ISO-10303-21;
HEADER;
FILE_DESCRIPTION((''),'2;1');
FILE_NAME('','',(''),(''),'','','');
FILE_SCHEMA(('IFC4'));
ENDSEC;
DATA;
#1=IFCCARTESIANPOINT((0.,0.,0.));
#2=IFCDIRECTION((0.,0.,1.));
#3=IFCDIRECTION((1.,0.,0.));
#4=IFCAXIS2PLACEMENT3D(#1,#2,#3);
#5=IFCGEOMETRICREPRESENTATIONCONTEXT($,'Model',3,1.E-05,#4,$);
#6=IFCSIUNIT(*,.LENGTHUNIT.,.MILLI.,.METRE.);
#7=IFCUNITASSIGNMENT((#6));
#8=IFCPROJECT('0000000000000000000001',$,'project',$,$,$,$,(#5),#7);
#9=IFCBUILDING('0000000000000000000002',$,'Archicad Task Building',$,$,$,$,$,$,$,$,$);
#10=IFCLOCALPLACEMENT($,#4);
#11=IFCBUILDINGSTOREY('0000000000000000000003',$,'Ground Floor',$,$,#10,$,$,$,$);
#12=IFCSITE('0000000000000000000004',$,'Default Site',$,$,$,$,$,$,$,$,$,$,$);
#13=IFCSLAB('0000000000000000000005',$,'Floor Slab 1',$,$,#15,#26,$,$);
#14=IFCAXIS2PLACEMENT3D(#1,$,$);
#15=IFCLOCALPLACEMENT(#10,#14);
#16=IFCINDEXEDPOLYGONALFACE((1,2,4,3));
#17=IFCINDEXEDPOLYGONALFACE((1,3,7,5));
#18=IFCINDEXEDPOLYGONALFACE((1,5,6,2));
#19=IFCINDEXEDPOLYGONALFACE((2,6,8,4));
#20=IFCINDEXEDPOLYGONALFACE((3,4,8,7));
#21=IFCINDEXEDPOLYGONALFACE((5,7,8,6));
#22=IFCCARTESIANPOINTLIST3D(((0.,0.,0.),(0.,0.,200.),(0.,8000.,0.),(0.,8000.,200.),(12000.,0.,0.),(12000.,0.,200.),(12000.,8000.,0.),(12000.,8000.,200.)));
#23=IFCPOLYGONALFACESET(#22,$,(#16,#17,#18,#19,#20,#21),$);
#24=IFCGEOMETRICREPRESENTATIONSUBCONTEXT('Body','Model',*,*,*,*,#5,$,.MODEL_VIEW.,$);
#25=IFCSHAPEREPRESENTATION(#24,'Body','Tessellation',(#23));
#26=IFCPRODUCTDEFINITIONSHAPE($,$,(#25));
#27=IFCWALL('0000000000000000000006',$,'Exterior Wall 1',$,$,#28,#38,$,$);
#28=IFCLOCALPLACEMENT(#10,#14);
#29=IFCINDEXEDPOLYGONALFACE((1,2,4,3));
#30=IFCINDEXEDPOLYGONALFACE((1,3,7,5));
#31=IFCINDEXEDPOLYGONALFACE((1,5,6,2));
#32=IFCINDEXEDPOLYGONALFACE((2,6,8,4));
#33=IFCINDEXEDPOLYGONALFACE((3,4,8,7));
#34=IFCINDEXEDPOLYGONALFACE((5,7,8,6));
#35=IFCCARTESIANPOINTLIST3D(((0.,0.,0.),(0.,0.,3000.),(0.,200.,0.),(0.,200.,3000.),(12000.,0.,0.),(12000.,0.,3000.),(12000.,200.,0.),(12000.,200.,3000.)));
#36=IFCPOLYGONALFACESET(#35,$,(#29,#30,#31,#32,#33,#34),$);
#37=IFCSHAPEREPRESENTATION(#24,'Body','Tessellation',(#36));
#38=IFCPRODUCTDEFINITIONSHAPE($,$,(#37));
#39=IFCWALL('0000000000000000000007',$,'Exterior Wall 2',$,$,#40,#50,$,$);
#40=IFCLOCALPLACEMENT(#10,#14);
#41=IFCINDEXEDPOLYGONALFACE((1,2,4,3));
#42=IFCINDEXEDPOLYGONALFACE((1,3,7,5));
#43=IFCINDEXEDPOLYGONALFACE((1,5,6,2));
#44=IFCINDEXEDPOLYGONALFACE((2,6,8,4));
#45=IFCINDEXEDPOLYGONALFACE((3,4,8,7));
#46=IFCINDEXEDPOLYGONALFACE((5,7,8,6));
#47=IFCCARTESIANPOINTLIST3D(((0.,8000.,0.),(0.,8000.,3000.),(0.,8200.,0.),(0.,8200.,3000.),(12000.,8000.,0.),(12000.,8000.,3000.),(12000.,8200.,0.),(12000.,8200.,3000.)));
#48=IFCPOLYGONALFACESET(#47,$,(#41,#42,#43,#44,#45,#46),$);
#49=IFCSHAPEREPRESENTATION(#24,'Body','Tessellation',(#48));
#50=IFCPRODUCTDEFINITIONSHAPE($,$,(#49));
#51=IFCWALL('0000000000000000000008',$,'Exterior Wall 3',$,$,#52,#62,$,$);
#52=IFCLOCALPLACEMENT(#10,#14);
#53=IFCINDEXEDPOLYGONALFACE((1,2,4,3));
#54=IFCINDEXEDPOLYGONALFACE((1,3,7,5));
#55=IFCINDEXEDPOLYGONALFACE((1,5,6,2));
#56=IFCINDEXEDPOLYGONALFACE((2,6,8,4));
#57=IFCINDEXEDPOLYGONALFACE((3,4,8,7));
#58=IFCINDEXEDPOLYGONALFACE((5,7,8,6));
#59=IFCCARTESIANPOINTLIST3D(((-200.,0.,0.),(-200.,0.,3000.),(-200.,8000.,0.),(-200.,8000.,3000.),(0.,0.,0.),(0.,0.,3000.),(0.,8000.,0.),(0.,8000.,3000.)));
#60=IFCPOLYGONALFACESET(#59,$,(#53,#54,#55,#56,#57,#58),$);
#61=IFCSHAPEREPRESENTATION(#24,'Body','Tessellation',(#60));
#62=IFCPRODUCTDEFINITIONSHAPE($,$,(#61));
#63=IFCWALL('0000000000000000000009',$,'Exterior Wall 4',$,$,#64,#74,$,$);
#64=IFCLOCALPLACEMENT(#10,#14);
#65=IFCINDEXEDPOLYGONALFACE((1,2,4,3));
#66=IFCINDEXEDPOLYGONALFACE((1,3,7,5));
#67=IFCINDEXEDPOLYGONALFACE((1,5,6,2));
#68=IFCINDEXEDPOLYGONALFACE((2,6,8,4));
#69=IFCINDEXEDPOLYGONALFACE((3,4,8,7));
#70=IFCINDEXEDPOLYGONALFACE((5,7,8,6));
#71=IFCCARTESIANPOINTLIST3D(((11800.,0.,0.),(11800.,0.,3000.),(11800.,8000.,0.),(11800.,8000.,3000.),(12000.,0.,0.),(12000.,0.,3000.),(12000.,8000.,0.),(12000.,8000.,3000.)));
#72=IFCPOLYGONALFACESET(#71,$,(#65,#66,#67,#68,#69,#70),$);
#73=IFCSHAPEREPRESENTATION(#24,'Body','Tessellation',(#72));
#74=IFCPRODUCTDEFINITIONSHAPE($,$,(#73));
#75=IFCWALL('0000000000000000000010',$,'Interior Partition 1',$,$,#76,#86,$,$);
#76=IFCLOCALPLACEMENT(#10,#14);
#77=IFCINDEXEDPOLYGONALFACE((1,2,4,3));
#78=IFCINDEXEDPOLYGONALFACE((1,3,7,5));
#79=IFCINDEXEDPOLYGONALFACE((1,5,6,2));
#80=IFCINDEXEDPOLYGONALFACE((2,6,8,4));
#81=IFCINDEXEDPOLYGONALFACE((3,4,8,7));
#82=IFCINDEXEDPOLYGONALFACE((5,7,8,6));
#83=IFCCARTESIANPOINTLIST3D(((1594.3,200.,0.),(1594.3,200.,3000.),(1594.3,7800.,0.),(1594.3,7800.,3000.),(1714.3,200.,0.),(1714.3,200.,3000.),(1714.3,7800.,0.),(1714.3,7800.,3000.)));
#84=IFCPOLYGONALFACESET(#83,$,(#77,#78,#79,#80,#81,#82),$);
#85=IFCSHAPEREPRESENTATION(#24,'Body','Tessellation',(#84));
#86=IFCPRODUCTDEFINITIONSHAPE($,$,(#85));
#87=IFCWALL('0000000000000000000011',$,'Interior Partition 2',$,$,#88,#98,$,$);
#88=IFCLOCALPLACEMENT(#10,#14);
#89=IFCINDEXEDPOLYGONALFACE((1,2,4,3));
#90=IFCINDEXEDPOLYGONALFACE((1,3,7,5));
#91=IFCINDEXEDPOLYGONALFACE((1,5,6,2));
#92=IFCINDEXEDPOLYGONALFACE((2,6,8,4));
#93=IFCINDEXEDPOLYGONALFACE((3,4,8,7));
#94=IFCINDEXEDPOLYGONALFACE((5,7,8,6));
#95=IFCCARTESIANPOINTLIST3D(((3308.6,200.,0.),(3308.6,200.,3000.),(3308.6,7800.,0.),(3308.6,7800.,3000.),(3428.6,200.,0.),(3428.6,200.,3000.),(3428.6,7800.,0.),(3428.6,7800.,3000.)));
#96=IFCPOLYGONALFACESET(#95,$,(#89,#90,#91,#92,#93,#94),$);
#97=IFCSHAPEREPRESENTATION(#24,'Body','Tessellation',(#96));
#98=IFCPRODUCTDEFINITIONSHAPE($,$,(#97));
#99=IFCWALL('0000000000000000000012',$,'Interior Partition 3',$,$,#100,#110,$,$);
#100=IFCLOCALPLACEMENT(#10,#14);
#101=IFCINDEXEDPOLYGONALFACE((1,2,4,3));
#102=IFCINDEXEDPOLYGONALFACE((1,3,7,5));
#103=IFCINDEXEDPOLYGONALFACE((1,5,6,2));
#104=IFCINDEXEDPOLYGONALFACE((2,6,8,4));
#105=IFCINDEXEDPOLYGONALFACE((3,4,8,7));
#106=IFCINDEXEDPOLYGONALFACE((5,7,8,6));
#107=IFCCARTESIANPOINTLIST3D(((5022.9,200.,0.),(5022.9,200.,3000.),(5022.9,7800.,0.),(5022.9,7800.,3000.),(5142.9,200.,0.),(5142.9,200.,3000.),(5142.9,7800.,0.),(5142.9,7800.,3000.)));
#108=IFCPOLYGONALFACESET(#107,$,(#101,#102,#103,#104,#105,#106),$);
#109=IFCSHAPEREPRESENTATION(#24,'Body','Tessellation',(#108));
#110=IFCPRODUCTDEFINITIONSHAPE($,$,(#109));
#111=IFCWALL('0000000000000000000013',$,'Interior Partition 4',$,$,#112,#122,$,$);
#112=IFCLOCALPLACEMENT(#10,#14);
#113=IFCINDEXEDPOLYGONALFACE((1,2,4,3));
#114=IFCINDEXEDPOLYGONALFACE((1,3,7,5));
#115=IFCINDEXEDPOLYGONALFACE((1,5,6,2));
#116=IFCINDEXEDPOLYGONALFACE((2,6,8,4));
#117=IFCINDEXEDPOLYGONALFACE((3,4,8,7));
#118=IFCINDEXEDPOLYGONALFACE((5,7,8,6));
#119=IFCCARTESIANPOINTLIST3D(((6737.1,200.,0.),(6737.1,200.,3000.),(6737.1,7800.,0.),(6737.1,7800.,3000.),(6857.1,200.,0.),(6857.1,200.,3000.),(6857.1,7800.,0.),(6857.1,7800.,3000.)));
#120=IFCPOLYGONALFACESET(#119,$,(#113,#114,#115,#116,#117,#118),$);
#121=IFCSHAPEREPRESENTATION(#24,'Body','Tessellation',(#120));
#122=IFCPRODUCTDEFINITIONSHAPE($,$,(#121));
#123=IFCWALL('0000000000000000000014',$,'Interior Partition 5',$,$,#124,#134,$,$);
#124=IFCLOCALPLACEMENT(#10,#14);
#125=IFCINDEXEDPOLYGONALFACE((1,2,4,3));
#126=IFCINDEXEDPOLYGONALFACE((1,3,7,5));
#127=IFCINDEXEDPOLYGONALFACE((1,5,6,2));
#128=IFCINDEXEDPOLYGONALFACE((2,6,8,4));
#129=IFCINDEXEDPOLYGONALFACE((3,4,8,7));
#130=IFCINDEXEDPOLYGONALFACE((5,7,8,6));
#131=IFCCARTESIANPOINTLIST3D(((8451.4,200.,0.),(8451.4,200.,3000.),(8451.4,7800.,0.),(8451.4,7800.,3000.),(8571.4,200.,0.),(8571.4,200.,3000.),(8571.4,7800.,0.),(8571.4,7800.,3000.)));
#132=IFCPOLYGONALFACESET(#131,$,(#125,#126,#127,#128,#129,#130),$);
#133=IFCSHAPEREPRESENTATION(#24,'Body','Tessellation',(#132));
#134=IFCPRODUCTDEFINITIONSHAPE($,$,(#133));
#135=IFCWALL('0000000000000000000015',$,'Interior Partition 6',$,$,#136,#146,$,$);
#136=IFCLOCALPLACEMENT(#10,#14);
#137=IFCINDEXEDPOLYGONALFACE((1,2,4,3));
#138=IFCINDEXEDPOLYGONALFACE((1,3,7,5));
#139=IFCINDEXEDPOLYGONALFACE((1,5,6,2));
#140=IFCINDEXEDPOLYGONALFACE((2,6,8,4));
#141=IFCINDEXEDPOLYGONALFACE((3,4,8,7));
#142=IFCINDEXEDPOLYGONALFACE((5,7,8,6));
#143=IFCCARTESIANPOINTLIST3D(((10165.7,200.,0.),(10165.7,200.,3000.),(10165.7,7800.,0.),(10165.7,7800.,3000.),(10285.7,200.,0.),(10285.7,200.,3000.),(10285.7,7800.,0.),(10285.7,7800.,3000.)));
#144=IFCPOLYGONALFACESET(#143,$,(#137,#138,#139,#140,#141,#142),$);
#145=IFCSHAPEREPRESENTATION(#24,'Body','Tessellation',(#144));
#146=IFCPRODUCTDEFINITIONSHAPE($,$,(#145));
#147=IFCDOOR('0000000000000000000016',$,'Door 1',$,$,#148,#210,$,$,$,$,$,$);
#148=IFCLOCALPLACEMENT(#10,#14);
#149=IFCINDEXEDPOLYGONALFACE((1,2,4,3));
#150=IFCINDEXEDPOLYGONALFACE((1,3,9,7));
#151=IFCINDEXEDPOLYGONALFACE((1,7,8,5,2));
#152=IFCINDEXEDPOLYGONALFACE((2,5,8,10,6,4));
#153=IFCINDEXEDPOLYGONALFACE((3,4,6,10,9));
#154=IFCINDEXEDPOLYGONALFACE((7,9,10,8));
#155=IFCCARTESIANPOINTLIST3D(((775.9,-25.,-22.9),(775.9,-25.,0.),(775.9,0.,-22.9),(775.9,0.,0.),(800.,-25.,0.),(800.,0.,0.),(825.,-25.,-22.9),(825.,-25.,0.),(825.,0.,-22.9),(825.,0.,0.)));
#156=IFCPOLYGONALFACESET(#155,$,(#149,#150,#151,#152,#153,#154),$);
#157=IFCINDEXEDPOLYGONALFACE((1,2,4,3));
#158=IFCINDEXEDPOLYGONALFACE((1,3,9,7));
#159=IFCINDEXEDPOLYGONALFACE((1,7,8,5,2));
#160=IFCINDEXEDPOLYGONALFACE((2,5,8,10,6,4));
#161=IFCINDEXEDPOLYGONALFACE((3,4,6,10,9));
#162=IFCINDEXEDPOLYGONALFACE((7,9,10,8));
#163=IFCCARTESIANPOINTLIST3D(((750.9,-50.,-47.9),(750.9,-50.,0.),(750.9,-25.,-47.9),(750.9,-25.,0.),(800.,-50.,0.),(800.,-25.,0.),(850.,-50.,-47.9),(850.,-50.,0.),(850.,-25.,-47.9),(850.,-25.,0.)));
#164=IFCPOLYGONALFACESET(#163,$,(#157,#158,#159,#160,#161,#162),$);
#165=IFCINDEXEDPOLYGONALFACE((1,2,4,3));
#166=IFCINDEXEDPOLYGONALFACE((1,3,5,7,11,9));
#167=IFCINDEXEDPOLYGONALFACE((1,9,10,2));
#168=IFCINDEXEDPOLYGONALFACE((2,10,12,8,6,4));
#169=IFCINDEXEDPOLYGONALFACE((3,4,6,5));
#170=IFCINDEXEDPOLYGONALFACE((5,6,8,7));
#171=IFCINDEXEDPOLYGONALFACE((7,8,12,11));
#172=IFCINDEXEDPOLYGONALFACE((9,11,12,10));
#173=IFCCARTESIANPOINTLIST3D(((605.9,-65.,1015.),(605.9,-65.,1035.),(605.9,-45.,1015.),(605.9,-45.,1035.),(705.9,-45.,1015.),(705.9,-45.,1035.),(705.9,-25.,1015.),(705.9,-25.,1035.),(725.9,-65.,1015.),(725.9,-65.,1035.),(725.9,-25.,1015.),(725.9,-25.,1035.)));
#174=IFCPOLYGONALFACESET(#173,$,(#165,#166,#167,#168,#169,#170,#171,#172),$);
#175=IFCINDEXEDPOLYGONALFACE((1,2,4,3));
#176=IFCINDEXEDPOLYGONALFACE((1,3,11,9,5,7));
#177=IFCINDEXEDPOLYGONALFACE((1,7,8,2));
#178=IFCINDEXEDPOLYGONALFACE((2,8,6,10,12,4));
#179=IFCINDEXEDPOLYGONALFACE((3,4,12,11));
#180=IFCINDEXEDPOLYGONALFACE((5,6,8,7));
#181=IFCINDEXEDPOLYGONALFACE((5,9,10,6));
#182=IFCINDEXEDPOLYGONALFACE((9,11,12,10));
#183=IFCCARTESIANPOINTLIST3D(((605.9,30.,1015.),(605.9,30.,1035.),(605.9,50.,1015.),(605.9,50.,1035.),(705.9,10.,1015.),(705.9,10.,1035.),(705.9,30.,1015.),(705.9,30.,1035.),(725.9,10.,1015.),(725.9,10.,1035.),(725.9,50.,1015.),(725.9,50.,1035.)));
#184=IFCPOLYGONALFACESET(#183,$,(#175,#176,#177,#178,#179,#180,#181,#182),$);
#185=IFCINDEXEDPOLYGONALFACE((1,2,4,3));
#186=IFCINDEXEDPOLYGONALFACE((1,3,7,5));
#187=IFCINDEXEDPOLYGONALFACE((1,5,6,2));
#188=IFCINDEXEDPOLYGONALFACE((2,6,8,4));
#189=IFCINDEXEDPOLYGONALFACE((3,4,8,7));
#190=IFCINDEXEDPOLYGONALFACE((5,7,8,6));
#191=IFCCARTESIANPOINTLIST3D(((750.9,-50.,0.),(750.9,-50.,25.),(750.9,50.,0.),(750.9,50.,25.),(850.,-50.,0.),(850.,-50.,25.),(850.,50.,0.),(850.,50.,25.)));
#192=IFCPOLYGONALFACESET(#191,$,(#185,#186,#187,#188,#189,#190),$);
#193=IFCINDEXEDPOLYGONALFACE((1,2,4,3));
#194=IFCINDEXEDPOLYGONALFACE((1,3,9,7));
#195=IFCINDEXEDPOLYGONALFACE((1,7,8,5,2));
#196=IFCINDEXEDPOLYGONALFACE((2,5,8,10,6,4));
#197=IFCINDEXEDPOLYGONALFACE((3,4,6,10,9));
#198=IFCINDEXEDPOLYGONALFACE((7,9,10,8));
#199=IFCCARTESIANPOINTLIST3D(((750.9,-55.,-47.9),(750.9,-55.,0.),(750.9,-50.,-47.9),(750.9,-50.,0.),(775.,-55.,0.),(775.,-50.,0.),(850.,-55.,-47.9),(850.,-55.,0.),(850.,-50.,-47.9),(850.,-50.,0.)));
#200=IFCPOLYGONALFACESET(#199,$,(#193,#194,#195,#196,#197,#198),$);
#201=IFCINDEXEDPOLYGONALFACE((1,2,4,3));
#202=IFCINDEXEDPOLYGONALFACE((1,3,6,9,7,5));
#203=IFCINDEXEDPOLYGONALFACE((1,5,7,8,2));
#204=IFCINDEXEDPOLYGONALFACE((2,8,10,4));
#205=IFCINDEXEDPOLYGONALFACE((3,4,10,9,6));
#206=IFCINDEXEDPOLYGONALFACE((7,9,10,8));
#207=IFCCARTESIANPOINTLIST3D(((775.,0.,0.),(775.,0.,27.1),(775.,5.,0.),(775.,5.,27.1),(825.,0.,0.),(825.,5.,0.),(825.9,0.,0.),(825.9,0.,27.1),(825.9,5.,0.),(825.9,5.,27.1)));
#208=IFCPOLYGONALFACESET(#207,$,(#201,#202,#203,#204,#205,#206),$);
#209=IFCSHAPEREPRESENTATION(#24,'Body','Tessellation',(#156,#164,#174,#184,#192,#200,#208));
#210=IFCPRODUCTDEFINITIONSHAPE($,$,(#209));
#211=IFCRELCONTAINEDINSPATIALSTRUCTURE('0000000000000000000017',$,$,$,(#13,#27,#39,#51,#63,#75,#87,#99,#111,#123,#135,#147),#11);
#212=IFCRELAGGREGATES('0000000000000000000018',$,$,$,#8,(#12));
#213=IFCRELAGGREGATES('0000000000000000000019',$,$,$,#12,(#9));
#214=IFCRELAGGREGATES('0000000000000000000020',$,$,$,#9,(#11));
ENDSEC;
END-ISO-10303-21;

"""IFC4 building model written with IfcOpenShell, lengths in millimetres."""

from ifc_helpers import new_model, si_unit, frame, origin_with_axes, place, context, subcontext, project, spatial, line, indexed_curve, outline, extrude, element, save


model = new_model("IFC4")

# Units and contexts
model_context = context("Model", 3, precision=1e-05, world=origin_with_axes())
body_context = subcontext(model_context, "Body", "Model", "MODEL_VIEW")
ifc_project = project(units=[si_unit("LENGTHUNIT", "METRE", prefix="MILLI")], contexts=[model_context])

# Site, building, storey
site = spatial("IfcSite", under=ifc_project, Name="Default Site")
building = spatial("IfcBuilding", under=site, Name="Archicad Task Building")
storey_placement = place(None, origin_with_axes())
storey = spatial("IfcBuildingStorey", under=building, at=storey_placement, Name="Ground Floor")

# Slab
slab_placement = place(storey_placement, origin_with_axes())
element("IfcSlab", 1, at=slab_placement, inside=storey, Name="Floor Slab 1", context=body_context, shape_type="SweptSolid", body=[
    extrude(outline(indexed_curve([(0.0, 0.0), (12000.0, 0.0), (12000.0, 8000.0), (0.0, 8000.0), (0.0, 0.0)])), None, (0.0, 0.0, 1.0), 200.0),
])

# Walls
for number, where, z_axis, x_axis, name in (
    (2, (0.0, 0.0, 0.0), (0.0, 0.0, 1.0), (1.0, 0.0, 0.0), "Exterior Wall 1"),
    (3, (0.0, 8000.0, 0.0), (0.0, 0.0, 1.0), (1.0, 0.0, 0.0), "Exterior Wall 2"),
):
    element("IfcWall", number, at=place(storey_placement, frame(where, z_axis=z_axis, x_axis=x_axis)), inside=storey, Name=name, context=body_context, shape_type="SweptSolid", body=[
        extrude(outline(indexed_curve([(0.0, 0.0), (0.0, 200.0), (12000.0, 200.0), (12000.0, 0.0), (0.0, 0.0)], self_intersect=False)), origin_with_axes(), (0.0, 0.0, 1.0), 3000.0),
    ])
for number, where, z_axis, x_axis, name in (
    (4, (0.0, 0.0, 0.0), (0.0, 0.0, 1.0), (0.0, 1.0, 0.0), "Exterior Wall 3"),
    (5, (12000.0, 0.0, 0.0), (0.0, 0.0, 1.0), (0.0, 1.0, 0.0), "Exterior Wall 4"),
):
    element("IfcWall", number, at=place(storey_placement, frame(where, z_axis=z_axis, x_axis=x_axis)), inside=storey, Name=name, context=body_context, shape_type="SweptSolid", body=[
        extrude(outline(indexed_curve([(0.0, 0.0), (0.0, 200.0), (8000.0, 200.0), (8000.0, 0.0), (0.0, 0.0)], self_intersect=False)), origin_with_axes(), (0.0, 0.0, 1.0), 3000.0),
    ])
for number, where, z_axis, x_axis, name in (
    (6, (1714.3, 200.0, 0.0), (0.0, 0.0, 1.0), (0.0, 1.0, 0.0), "Interior Partition 1"),
    (7, (3428.6, 200.0, 0.0), (0.0, 0.0, 1.0), (0.0, 1.0, 0.0), "Interior Partition 2"),
    (8, (5142.9, 200.0, 0.0), (0.0, 0.0, 1.0), (0.0, 1.0, 0.0), "Interior Partition 3"),
    (9, (6857.1, 200.0, 0.0), (0.0, 0.0, 1.0), (0.0, 1.0, 0.0), "Interior Partition 4"),
    (10, (8571.4, 200.0, 0.0), (0.0, 0.0, 1.0), (0.0, 1.0, 0.0), "Interior Partition 5"),
    (11, (10285.7, 200.0, 0.0), (0.0, 0.0, 1.0), (0.0, 1.0, 0.0), "Interior Partition 6"),
):
    element("IfcWall", number, at=place(storey_placement, frame(where, z_axis=z_axis, x_axis=x_axis)), inside=storey, Name=name, context=body_context, shape_type="SweptSolid", body=[
        extrude(outline(indexed_curve([(0.0, 0.0), (0.0, 120.0), (7600.0, 120.0), (7600.0, 0.0), (0.0, 0.0)], self_intersect=False)), origin_with_axes(), (0.0, 0.0, 1.0), 3000.0),
    ])

# Door
door_1_placement = place(storey_placement, frame((800.0, -50.0, 0.0), z_axis=(0.0, 0.0, 1.0), x_axis=(1.0, 0.0, 0.0)))
element("IfcDoor", 12, at=door_1_placement, inside=storey, Name="Door 1", context=body_context, shape_type="SweptSolid", body=[
    extrude(outline(indexed_curve([(0.0, 0.0), (0.0, 2.1), (0.9, 2.1), (0.9, 0.0), (-24.1, 0.0), (-24.1, -22.9), (25.0, -22.9), (25.0, 0.0)], segments=[line(1, 2, 3, 4, 5, 6, 7, 8, 1)])), frame((0.0, 25.0, 0.0), z_axis=(0.0, -1.0, 0.0), x_axis=(1.0, 0.0, 0.0)), (0.0, 0.0, -1.0), 25.0),
    extrude(outline(indexed_curve([(0.0, 0.0), (0.0, 2.1), (0.9, 2.1), (0.9, 0.0), (-49.1, 0.0), (-49.1, -47.9), (50.0, -47.9), (50.0, 0.0)], segments=[line(1, 2, 3, 4, 5, 6, 7, 8, 1)])), frame((0.0, 0.0, 0.0), z_axis=(0.0, -1.0, 0.0), x_axis=(1.0, 0.0, 0.0)), (0.0, 0.0, -1.0), 25.0),
    extrude(outline(indexed_curve([(0.0, 0.0), (-49.1, 0.0), (-49.1, 35.0), (0.0, 35.0)], segments=[line(1, 2, 3, 4, 1)])), frame((25.0, 25.0, 25.0), z_axis=(0.0, 0.0, 1.0), x_axis=(1.0, 0.0, 0.0)), (0.0, 0.0, 1.0), -47.9),
    extrude(outline(indexed_curve([(0.0, 0.0), (0.0, -40.0), (-120.0, -40.0), (-120.0, -20.0), (-20.0, -20.0), (-20.0, 0.0)], segments=[line(1, 2, 3, 4, 5, 6, 1)])), frame((-74.1, 25.0, 1015.0), z_axis=(0.0, 0.0, 1.0), x_axis=(1.0, 0.0, 0.0)), (0.0, 0.0, 1.0), 20.0),
    extrude(outline(indexed_curve([(0.0, 0.0), (0.0, 40.0), (-120.0, 40.0), (-120.0, 20.0), (-20.0, 20.0), (-20.0, 0.0)], segments=[line(1, 2, 3, 4, 5, 6, 1)])), frame((-74.1, 60.0, 1015.0), z_axis=(0.0, 0.0, 1.0), x_axis=(1.0, 0.0, 0.0)), (0.0, 0.0, 1.0), 20.0),
    extrude(outline(indexed_curve([(0.0, 0.0), (-99.1, 0.0), (-99.1, 100.0), (0.0, 100.0)], segments=[line(1, 2, 3, 4, 1)])), frame((50.0, 0.0, 0.0), z_axis=(0.0, 0.0, 1.0), x_axis=(1.0, 0.0, 0.0)), (0.0, 0.0, 1.0), 25.0),
    extrude(outline(indexed_curve([(0.0, 0.0), (0.0, 27.1), (50.9, 27.1), (50.9, 0.0), (-24.1, 0.0), (-24.1, -47.9), (75.0, -47.9), (75.0, 0.0)], segments=[line(1, 2, 3, 4, 5, 6, 7, 8, 1)])), frame((-25.0, -5.0, 0.0), z_axis=(0.0, -1.0, 0.0), x_axis=(1.0, 0.0, 0.0)), (0.0, 0.0, -1.0), 5.0),
    extrude(outline(indexed_curve([(0.0, 0.0), (0.0, 27.1), (50.9, 27.1), (50.9, 0.0), (0.9, 0.0), (0.9, -22.9), (50.0, -22.9), (50.0, 0.0)], segments=[line(1, 2, 3, 4, 5, 6, 7, 8, 1)])), frame((-25.0, 50.0, 0.0), z_axis=(0.0, -1.0, 0.0), x_axis=(1.0, 0.0, 0.0)), (0.0, 0.0, -1.0), 5.0),
])

save(model, "model.ifc")
